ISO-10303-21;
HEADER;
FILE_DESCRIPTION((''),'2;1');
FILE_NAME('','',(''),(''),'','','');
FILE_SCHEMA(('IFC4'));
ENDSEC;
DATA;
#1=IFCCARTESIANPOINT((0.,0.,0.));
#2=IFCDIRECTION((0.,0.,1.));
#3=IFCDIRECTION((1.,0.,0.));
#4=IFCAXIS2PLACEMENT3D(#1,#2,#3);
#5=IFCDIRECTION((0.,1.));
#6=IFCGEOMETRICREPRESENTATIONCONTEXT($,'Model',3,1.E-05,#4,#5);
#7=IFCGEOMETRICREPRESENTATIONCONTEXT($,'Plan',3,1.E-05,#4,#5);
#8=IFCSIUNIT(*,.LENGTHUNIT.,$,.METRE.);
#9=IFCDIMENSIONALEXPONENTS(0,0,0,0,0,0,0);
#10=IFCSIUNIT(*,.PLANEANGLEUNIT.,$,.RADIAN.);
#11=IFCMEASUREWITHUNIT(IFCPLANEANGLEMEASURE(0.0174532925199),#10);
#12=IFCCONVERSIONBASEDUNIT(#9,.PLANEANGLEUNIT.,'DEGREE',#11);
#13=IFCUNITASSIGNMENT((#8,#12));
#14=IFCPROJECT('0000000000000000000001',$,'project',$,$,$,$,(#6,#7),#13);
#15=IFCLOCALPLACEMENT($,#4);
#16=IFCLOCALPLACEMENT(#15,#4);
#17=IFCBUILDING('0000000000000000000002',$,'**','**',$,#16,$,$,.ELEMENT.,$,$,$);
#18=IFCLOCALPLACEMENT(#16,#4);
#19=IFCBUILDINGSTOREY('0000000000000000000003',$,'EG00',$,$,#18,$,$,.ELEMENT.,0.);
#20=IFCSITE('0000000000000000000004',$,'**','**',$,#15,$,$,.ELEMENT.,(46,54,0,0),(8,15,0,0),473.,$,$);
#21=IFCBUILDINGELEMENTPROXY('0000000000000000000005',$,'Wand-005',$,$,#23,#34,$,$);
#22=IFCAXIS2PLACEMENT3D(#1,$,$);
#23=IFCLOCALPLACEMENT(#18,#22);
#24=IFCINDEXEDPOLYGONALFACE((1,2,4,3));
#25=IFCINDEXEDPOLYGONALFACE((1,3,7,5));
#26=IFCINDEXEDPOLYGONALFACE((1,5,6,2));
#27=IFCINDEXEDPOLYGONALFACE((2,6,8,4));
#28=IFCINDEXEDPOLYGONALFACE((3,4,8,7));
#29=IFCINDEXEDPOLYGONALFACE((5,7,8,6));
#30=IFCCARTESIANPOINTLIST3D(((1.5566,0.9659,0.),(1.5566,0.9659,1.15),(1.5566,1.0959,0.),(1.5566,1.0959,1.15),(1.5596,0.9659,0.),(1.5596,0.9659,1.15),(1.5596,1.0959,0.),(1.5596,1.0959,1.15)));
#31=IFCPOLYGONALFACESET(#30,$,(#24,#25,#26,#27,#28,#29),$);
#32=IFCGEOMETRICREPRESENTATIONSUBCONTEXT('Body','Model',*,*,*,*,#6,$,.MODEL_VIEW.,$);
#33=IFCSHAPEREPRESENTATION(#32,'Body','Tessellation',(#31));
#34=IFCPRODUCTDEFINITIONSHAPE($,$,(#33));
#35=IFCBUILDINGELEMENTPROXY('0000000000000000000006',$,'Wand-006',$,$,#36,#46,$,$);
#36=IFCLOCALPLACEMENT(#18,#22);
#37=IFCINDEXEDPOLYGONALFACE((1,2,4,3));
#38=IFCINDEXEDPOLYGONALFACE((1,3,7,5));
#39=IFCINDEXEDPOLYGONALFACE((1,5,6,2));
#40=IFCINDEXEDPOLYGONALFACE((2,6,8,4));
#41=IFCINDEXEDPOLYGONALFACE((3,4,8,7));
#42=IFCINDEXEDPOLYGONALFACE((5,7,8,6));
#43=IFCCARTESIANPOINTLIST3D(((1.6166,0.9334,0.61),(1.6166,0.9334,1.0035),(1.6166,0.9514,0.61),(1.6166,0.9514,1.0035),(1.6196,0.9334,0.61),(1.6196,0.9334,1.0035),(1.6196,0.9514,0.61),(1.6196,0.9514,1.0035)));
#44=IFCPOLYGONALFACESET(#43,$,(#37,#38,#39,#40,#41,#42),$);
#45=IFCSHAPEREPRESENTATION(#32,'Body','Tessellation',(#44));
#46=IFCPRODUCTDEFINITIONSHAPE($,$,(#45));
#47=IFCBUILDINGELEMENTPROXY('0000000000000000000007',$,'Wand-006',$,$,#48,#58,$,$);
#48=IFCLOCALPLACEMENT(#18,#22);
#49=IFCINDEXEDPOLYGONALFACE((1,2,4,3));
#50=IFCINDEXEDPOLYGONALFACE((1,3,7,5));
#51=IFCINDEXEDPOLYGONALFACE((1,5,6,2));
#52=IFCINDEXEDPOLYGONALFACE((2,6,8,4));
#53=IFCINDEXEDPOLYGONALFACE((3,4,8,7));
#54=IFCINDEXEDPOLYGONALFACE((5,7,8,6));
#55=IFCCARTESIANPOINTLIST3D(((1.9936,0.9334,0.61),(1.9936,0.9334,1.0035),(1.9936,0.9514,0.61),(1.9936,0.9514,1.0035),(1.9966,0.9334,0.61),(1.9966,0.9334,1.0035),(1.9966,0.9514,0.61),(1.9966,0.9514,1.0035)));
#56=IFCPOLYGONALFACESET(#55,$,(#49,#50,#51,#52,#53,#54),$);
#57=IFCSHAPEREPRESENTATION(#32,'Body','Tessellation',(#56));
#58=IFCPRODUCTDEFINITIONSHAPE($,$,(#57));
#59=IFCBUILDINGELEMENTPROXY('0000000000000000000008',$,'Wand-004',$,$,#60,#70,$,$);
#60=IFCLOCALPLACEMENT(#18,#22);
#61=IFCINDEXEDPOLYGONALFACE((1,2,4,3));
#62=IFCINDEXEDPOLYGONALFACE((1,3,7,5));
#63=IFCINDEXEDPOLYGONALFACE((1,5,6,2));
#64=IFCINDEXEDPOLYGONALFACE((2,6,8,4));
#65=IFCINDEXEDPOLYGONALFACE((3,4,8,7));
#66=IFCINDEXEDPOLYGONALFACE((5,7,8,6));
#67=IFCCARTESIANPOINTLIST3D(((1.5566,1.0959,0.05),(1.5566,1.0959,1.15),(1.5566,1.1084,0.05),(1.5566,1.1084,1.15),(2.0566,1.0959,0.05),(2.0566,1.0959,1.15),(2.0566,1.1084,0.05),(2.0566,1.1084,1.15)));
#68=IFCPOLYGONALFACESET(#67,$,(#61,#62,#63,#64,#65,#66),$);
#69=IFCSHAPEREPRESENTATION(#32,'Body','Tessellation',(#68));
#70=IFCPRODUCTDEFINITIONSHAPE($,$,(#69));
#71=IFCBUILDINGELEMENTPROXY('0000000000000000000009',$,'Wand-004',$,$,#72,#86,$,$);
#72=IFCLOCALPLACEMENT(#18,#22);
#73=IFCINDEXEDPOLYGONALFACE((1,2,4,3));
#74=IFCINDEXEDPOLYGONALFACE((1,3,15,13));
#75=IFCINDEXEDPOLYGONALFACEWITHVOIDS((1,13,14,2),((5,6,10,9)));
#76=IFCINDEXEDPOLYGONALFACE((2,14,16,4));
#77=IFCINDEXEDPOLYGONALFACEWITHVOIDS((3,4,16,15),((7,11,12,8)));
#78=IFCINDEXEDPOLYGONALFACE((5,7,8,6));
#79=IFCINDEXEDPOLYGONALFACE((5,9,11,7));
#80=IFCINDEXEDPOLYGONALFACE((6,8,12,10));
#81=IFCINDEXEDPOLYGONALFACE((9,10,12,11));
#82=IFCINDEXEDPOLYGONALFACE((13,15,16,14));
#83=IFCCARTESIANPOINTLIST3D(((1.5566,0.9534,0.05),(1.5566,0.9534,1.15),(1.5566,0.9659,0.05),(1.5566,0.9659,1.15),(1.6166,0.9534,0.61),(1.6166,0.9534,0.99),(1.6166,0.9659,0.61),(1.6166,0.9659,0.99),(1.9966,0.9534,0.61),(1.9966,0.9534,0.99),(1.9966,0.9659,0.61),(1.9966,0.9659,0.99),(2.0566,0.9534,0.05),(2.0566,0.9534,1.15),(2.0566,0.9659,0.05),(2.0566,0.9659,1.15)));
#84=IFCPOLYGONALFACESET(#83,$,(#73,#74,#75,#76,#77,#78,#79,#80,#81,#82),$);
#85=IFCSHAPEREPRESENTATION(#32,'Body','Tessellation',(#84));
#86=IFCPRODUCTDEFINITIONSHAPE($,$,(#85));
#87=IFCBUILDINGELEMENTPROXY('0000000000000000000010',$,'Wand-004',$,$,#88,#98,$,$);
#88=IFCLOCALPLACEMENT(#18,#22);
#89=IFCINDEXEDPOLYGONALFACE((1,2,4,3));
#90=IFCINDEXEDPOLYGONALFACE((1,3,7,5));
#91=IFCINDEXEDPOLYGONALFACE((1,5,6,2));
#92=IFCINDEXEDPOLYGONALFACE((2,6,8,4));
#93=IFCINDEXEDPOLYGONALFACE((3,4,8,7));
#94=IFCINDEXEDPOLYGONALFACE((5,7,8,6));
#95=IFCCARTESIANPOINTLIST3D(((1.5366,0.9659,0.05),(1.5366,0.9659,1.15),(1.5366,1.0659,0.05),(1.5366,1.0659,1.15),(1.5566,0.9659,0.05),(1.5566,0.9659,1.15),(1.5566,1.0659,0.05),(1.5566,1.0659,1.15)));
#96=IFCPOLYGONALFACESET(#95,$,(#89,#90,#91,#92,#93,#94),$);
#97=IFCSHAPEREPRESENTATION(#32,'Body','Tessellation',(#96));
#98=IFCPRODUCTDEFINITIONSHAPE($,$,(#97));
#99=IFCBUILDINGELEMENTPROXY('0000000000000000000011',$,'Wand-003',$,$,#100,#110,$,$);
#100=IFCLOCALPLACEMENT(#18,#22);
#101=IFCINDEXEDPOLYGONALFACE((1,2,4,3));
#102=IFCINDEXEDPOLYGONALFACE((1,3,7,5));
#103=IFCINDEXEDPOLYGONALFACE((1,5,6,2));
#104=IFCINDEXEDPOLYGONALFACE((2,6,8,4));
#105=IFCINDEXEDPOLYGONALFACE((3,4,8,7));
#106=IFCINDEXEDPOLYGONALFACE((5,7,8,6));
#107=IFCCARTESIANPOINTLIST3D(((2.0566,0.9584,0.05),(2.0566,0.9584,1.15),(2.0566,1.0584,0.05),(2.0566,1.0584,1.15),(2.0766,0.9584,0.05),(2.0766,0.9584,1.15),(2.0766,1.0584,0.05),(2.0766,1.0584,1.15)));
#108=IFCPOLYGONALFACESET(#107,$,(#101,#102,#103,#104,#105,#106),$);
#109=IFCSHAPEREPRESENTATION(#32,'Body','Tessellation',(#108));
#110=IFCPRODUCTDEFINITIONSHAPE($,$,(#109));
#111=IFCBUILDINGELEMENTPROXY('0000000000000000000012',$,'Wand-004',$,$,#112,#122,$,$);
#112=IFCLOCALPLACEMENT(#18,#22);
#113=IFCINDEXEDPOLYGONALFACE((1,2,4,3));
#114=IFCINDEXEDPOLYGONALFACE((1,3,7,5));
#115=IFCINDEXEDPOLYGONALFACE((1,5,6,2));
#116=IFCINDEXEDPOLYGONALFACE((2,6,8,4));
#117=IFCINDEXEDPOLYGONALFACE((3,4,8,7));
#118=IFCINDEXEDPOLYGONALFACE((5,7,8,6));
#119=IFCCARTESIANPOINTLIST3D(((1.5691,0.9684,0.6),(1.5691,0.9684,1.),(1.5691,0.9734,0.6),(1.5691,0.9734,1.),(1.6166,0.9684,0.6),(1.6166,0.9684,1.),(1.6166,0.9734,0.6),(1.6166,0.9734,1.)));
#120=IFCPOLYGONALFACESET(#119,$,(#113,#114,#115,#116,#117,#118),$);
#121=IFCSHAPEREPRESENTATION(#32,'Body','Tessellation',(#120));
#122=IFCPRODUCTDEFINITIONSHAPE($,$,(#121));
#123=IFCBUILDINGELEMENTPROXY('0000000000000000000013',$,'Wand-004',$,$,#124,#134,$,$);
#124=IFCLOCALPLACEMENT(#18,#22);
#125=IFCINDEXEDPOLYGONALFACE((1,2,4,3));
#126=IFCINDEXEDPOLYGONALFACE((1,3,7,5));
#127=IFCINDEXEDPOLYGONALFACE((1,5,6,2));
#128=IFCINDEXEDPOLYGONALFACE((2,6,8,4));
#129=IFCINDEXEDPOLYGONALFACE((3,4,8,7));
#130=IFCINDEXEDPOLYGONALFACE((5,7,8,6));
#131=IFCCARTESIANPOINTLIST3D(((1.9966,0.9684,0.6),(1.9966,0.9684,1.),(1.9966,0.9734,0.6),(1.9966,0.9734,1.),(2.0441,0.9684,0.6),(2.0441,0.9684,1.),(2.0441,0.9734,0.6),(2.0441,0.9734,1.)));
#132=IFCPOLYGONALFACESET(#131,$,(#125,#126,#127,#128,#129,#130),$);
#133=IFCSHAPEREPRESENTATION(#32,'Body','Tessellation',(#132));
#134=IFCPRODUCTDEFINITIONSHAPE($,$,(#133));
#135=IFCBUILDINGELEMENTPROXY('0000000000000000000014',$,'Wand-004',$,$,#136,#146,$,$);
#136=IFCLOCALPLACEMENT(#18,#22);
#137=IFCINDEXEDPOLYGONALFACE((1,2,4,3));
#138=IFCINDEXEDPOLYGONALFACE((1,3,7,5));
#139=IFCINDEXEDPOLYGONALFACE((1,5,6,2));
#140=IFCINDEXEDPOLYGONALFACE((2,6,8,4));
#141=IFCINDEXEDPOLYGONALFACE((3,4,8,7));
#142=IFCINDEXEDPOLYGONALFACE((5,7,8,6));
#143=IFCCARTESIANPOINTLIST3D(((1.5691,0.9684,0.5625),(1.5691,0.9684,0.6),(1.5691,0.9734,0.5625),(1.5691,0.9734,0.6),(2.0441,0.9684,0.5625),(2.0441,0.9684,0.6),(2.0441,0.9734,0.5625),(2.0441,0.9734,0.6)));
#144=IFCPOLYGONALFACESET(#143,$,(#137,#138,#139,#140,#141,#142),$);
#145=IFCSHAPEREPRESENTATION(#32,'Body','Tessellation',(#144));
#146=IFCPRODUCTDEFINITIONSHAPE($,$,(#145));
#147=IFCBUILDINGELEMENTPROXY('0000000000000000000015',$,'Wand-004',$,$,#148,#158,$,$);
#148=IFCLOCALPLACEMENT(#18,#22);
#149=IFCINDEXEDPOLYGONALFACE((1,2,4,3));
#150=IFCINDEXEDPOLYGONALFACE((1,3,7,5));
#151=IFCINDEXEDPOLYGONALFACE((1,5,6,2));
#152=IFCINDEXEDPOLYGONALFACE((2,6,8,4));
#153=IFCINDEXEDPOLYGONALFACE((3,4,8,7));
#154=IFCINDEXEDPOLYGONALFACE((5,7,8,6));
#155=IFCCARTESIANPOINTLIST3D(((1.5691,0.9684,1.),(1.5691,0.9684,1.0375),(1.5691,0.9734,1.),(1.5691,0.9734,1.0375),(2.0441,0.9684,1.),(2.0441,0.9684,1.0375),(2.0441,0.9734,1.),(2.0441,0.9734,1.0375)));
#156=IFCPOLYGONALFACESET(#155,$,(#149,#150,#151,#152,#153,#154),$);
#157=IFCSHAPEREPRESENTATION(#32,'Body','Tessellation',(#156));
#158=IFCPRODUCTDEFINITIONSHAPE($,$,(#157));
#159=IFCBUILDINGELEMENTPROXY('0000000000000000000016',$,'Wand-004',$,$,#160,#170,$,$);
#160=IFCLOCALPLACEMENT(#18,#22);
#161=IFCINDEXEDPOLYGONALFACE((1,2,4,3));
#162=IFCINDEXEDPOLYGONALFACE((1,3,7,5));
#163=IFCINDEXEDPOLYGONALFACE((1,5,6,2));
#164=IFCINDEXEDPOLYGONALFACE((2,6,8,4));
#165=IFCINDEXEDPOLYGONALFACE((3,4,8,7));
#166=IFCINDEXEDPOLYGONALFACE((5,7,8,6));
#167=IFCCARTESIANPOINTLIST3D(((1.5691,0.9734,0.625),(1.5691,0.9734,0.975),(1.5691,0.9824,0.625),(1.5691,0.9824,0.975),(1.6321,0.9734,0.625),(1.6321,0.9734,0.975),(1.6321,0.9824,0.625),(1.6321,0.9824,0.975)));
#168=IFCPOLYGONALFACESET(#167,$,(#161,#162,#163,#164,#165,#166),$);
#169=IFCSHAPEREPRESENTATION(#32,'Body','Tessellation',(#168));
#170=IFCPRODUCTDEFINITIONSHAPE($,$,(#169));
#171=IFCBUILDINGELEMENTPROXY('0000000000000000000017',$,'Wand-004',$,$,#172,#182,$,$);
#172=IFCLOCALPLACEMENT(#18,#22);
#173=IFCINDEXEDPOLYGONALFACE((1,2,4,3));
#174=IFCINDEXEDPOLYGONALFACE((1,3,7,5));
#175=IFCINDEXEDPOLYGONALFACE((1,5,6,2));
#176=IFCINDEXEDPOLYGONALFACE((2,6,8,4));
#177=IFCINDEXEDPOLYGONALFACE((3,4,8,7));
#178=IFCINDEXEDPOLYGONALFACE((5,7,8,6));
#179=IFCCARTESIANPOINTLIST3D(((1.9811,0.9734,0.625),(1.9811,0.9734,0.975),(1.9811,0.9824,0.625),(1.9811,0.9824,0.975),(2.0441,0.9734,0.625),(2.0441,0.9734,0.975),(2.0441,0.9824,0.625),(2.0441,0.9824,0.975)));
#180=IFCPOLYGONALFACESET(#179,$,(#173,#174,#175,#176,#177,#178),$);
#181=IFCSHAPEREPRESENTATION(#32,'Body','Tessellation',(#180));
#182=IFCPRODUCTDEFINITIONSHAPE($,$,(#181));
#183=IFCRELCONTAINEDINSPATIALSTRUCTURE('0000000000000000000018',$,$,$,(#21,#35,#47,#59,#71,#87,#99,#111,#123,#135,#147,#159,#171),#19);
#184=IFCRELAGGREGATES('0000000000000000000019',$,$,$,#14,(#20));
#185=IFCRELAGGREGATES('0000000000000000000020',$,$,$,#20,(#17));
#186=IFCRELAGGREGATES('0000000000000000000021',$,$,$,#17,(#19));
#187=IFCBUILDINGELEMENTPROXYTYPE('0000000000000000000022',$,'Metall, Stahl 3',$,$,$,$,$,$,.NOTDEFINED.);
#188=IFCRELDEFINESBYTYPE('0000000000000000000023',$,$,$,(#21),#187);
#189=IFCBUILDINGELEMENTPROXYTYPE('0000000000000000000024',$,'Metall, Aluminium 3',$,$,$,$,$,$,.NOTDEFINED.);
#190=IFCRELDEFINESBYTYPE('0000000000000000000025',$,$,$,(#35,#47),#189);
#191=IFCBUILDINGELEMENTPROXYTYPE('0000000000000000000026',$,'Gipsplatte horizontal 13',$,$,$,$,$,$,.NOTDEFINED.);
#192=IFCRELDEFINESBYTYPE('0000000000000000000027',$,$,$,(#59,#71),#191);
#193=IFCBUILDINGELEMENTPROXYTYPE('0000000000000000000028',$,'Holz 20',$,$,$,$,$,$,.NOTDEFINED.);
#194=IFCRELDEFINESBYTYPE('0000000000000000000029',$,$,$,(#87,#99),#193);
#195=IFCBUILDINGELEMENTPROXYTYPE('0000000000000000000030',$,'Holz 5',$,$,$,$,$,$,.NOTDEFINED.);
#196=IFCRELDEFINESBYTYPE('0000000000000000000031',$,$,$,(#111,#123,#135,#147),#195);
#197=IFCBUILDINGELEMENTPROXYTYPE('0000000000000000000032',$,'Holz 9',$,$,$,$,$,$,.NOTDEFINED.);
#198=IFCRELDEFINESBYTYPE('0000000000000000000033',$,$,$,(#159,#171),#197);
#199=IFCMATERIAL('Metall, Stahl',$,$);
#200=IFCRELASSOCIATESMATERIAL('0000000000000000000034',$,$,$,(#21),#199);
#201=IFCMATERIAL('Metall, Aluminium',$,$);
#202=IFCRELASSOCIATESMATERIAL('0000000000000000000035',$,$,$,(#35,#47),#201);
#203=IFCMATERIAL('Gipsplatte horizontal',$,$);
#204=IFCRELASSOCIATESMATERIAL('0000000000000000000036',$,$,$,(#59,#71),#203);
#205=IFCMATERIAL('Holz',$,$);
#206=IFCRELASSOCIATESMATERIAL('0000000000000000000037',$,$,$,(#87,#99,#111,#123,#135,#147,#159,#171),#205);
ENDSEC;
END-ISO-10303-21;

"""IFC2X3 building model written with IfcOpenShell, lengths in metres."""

from ifc_helpers import new_model, entity, si_unit, converted_unit, direction, frame, origin_with_axes, origin_2d_with_axis, place, context, subcontext, project, spatial, polyline, rectangle, outline, extrude, material, type_object, element, save


model = new_model("IFC2X3")

# Units and contexts
model_context = context("Model", 3, precision=1e-05, world=origin_with_axes(), true_north=direction((0.0, 1.0)))
plan_context = context("Plan", 3, precision=1e-05, world=origin_with_axes(), true_north=direction((0.0, 1.0)))
body_context = subcontext(model_context, "Body", "Model", "MODEL_VIEW")
ifc_project = project(units=[si_unit("LENGTHUNIT", "METRE"), converted_unit("PLANEANGLEUNIT", "DEGREE", entity("IfcPlaneAngleMeasure", 0.0174532925199), si_unit("PLANEANGLEUNIT", "RADIAN"), dimensions=[0, 0, 0, 0, 0, 0, 0])], contexts=[model_context, plan_context])

# Site, building, storey
site_placement = place(None, origin_with_axes())
site = spatial("IfcSite", under=ifc_project, at=site_placement, Name="**", Description="**", CompositionType="ELEMENT", RefLatitude=(46, 54, 0, 0), RefLongitude=(8, 15, 0, 0), RefElevation=473.0)
building_placement = place(site_placement, origin_with_axes())
building = spatial("IfcBuilding", under=site, at=building_placement, Name="**", Description="**", CompositionType="ELEMENT")
storey_placement = place(building_placement, origin_with_axes())
storey = spatial("IfcBuildingStorey", under=building, at=storey_placement, Name="EG00", CompositionType="ELEMENT", Elevation=0.0)

# Building element proxies
ifc_material_1 = material(Name="Metall, Stahl")
building_element_proxy_type_1 = type_object("IfcBuildingElementProxyType", Name="Metall, Stahl 3", PredefinedType="NOTDEFINED")
proxy_1_placement = place(storey_placement, frame((1.5566, 1.0959, 0.0), z_axis=(0.0, 0.0, 1.0), x_axis=(0.0, -1.0, 0.0)))
element("IfcBuildingElementProxy", 1, at=proxy_1_placement, inside=storey, type_object=building_element_proxy_type_1, material=ifc_material_1, Name="Wand-005", context=body_context, shape_type="SweptSolid", body=[
    extrude(outline(polyline([(0.0, 0.0), (0.13, 0.0), (0.13, 0.003), (0.0, 0.003), (0.0, 0.0)])), origin_with_axes(), (0.0, 0.0, 1.0), 1.15),
])
ifc_material_2 = material(Name="Metall, Aluminium")
building_element_proxy_type_2 = type_object("IfcBuildingElementProxyType", Name="Metall, Aluminium 3", PredefinedType="NOTDEFINED")
proxy_2_placement = place(storey_placement, frame((1.6166, 0.9514, 0.61), z_axis=(0.0, 0.0, 1.0), x_axis=(0.0, -1.0, 0.0)))
element("IfcBuildingElementProxy", 2, at=proxy_2_placement, inside=storey, type_object=building_element_proxy_type_2, material=ifc_material_2, Name="Wand-006", context=body_context, shape_type="SweptSolid", body=[
    extrude(outline(polyline([(0.0, 0.0), (0.018, 0.0), (0.018, 0.003), (0.0, 0.003), (0.0, 0.0)])), origin_with_axes(), (0.0, 0.0, 1.0), 0.3935),
])
proxy_3_placement = place(storey_placement, frame((1.9966, 0.9514, 0.61), z_axis=(0.0, 0.0, 1.0), x_axis=(0.0, -1.0, 0.0)))
element("IfcBuildingElementProxy", 3, at=proxy_3_placement, inside=storey, type_object=building_element_proxy_type_2, material=ifc_material_2, Name="Wand-006", context=body_context, shape_type="SweptSolid", body=[
    extrude(outline(polyline([(0.0, -0.003), (0.018, -0.003), (0.018, 0.0), (0.0, 0.0), (0.0, -0.003)])), origin_with_axes(), (0.0, 0.0, 1.0), 0.3935),
])
ifc_material_3 = material(Name="Gipsplatte horizontal")
building_element_proxy_type_3 = type_object("IfcBuildingElementProxyType", Name="Gipsplatte horizontal 13", PredefinedType="NOTDEFINED")
proxy_4_placement = place(storey_placement, frame((1.5566, 1.1084, 0.05), z_axis=(0.0, 0.0, 1.0), x_axis=(1.0, 0.0, 0.0)))
element("IfcBuildingElementProxy", 4, at=proxy_4_placement, inside=storey, type_object=building_element_proxy_type_3, material=ifc_material_3, Name="Wand-004", context=body_context, shape_type="SweptSolid", body=[
    extrude(outline(polyline([(0.0, -0.0125), (0.5, -0.0125), (0.5, 0.0), (0.0, 0.0), (0.0, -0.0125)])), origin_with_axes(), (0.0, 0.0, 1.0), 1.1),
])

# Building element proxy, opening
proxy_5_placement = place(storey_placement, frame((1.5566, 0.9534, 0.05), z_axis=(0.0, 0.0, 1.0), x_axis=(1.0, 0.0, 0.0)))
proxy_5 = element("IfcBuildingElementProxy", 5, at=proxy_5_placement, inside=storey, type_object=building_element_proxy_type_3, material=ifc_material_3, Name="Wand-004", context=body_context, shape_type="SweptSolid", body=[
    extrude(outline(polyline([(0.0, 0.0), (0.5, 0.0), (0.5, 0.0125), (0.0, 0.0125), (0.0, 0.0)])), origin_with_axes(), (0.0, 0.0, 1.0), 1.1),
])
opening_placement = place(proxy_5_placement, frame((-1.5566, -0.9534, -0.05), z_axis=(0.0, 0.0, 1.0), x_axis=(1.0, 0.0, 0.0)))
element("IfcOpeningElement", 6, at=opening_placement, cuts=proxy_5, context=body_context, shape_type="SweptSolid", body=[
    extrude(rectangle(XDim=0.38, YDim=0.38, at=origin_2d_with_axis()), frame((1.8066, 0.9284, 0.8), z_axis=(0.0, -1.0, 0.0), x_axis=(1.0, 0.0, 0.0)), (0.0, 0.0, -1.0), 0.05),
])

# Building element proxies
ifc_material_4 = material(Name="Holz")
building_element_proxy_type_4 = type_object("IfcBuildingElementProxyType", Name="Holz 20", PredefinedType="NOTDEFINED")
proxy_6_placement = place(storey_placement, frame((1.5366, 1.0659, 0.05), z_axis=(0.0, 0.0, 1.0), x_axis=(0.0, -1.0, 0.0)))
element("IfcBuildingElementProxy", 7, at=proxy_6_placement, inside=storey, type_object=building_element_proxy_type_4, material=ifc_material_4, Name="Wand-004", context=body_context, shape_type="SweptSolid", body=[
    extrude(outline(polyline([(0.0, 0.0), (0.1, 0.0), (0.1, 0.02), (0.0, 0.02), (0.0, 0.0)])), origin_with_axes(), (0.0, 0.0, 1.0), 1.1),
])
proxy_7_placement = place(storey_placement, frame((2.0766, 1.0584, 0.05), z_axis=(0.0, 0.0, 1.0), x_axis=(0.0, -1.0, 0.0)))
element("IfcBuildingElementProxy", 8, at=proxy_7_placement, inside=storey, type_object=building_element_proxy_type_4, material=ifc_material_4, Name="Wand-003", context=body_context, shape_type="SweptSolid", body=[
    extrude(outline(polyline([(0.0, -0.02), (0.1, -0.02), (0.1, 0.0), (0.0, 0.0), (0.0, -0.02)])), origin_with_axes(), (0.0, 0.0, 1.0), 1.1),
])
building_element_proxy_type_5 = type_object("IfcBuildingElementProxyType", Name="Holz 5", PredefinedType="NOTDEFINED")
for number, where, z_axis, x_axis, name in (
    (9, (1.5691, 0.9684, 0.6), (0.0, 0.0, 1.0), (1.0, 0.0, 0.0), "Wand-004"),
    (10, (1.9966, 0.9684, 0.6), (0.0, 0.0, 1.0), (1.0, 0.0, 0.0), "Wand-004"),
):
    element("IfcBuildingElementProxy", number, at=place(storey_placement, frame(where, z_axis=z_axis, x_axis=x_axis)), inside=storey, type_object=building_element_proxy_type_5, material=ifc_material_4, Name=name, context=body_context, shape_type="SweptSolid", body=[
        extrude(outline(polyline([(0.0, 0.0), (0.0475, 0.0), (0.0475, 0.005), (0.0, 0.005), (0.0, 0.0)])), origin_with_axes(), (0.0, 0.0, 1.0), 0.4),
    ])
for number, where, z_axis, x_axis, name in (
    (11, (2.0441, 0.9684, 0.5625), (0.0, 0.0, 1.0), (-1.0, 0.0, 0.0), "Wand-004"),
    (12, (2.0441, 0.9684, 1.0), (0.0, 0.0, 1.0), (-1.0, 0.0, 0.0), "Wand-004"),
):
    element("IfcBuildingElementProxy", number, at=place(storey_placement, frame(where, z_axis=z_axis, x_axis=x_axis)), inside=storey, type_object=building_element_proxy_type_5, material=ifc_material_4, Name=name, context=body_context, shape_type="SweptSolid", body=[
        extrude(outline(polyline([(0.0, -0.005), (0.475, -0.005), (0.475, 0.0), (0.0, 0.0), (0.0, -0.005)])), origin_with_axes(), (0.0, 0.0, 1.0), 0.0375),
    ])
building_element_proxy_type_6 = type_object("IfcBuildingElementProxyType", Name="Holz 9", PredefinedType="NOTDEFINED")
for number, where, z_axis, x_axis, name in (
    (13, (1.5691, 0.9734, 0.625), (0.0, 0.0, 1.0), (1.0, 0.0, 0.0), "Wand-004"),
    (14, (1.9811, 0.9734, 0.625), (0.0, 0.0, 1.0), (1.0, 0.0, 0.0), "Wand-004"),
):
    element("IfcBuildingElementProxy", number, at=place(storey_placement, frame(where, z_axis=z_axis, x_axis=x_axis)), inside=storey, type_object=building_element_proxy_type_6, material=ifc_material_4, Name=name, context=body_context, shape_type="SweptSolid", body=[
        extrude(outline(polyline([(0.0, 0.0), (0.063, 0.0), (0.063, 0.009), (0.0, 0.009), (0.0, 0.0)])), origin_with_axes(), (0.0, 0.0, 1.0), 0.35),
    ])

save(model, "model.ifc")
